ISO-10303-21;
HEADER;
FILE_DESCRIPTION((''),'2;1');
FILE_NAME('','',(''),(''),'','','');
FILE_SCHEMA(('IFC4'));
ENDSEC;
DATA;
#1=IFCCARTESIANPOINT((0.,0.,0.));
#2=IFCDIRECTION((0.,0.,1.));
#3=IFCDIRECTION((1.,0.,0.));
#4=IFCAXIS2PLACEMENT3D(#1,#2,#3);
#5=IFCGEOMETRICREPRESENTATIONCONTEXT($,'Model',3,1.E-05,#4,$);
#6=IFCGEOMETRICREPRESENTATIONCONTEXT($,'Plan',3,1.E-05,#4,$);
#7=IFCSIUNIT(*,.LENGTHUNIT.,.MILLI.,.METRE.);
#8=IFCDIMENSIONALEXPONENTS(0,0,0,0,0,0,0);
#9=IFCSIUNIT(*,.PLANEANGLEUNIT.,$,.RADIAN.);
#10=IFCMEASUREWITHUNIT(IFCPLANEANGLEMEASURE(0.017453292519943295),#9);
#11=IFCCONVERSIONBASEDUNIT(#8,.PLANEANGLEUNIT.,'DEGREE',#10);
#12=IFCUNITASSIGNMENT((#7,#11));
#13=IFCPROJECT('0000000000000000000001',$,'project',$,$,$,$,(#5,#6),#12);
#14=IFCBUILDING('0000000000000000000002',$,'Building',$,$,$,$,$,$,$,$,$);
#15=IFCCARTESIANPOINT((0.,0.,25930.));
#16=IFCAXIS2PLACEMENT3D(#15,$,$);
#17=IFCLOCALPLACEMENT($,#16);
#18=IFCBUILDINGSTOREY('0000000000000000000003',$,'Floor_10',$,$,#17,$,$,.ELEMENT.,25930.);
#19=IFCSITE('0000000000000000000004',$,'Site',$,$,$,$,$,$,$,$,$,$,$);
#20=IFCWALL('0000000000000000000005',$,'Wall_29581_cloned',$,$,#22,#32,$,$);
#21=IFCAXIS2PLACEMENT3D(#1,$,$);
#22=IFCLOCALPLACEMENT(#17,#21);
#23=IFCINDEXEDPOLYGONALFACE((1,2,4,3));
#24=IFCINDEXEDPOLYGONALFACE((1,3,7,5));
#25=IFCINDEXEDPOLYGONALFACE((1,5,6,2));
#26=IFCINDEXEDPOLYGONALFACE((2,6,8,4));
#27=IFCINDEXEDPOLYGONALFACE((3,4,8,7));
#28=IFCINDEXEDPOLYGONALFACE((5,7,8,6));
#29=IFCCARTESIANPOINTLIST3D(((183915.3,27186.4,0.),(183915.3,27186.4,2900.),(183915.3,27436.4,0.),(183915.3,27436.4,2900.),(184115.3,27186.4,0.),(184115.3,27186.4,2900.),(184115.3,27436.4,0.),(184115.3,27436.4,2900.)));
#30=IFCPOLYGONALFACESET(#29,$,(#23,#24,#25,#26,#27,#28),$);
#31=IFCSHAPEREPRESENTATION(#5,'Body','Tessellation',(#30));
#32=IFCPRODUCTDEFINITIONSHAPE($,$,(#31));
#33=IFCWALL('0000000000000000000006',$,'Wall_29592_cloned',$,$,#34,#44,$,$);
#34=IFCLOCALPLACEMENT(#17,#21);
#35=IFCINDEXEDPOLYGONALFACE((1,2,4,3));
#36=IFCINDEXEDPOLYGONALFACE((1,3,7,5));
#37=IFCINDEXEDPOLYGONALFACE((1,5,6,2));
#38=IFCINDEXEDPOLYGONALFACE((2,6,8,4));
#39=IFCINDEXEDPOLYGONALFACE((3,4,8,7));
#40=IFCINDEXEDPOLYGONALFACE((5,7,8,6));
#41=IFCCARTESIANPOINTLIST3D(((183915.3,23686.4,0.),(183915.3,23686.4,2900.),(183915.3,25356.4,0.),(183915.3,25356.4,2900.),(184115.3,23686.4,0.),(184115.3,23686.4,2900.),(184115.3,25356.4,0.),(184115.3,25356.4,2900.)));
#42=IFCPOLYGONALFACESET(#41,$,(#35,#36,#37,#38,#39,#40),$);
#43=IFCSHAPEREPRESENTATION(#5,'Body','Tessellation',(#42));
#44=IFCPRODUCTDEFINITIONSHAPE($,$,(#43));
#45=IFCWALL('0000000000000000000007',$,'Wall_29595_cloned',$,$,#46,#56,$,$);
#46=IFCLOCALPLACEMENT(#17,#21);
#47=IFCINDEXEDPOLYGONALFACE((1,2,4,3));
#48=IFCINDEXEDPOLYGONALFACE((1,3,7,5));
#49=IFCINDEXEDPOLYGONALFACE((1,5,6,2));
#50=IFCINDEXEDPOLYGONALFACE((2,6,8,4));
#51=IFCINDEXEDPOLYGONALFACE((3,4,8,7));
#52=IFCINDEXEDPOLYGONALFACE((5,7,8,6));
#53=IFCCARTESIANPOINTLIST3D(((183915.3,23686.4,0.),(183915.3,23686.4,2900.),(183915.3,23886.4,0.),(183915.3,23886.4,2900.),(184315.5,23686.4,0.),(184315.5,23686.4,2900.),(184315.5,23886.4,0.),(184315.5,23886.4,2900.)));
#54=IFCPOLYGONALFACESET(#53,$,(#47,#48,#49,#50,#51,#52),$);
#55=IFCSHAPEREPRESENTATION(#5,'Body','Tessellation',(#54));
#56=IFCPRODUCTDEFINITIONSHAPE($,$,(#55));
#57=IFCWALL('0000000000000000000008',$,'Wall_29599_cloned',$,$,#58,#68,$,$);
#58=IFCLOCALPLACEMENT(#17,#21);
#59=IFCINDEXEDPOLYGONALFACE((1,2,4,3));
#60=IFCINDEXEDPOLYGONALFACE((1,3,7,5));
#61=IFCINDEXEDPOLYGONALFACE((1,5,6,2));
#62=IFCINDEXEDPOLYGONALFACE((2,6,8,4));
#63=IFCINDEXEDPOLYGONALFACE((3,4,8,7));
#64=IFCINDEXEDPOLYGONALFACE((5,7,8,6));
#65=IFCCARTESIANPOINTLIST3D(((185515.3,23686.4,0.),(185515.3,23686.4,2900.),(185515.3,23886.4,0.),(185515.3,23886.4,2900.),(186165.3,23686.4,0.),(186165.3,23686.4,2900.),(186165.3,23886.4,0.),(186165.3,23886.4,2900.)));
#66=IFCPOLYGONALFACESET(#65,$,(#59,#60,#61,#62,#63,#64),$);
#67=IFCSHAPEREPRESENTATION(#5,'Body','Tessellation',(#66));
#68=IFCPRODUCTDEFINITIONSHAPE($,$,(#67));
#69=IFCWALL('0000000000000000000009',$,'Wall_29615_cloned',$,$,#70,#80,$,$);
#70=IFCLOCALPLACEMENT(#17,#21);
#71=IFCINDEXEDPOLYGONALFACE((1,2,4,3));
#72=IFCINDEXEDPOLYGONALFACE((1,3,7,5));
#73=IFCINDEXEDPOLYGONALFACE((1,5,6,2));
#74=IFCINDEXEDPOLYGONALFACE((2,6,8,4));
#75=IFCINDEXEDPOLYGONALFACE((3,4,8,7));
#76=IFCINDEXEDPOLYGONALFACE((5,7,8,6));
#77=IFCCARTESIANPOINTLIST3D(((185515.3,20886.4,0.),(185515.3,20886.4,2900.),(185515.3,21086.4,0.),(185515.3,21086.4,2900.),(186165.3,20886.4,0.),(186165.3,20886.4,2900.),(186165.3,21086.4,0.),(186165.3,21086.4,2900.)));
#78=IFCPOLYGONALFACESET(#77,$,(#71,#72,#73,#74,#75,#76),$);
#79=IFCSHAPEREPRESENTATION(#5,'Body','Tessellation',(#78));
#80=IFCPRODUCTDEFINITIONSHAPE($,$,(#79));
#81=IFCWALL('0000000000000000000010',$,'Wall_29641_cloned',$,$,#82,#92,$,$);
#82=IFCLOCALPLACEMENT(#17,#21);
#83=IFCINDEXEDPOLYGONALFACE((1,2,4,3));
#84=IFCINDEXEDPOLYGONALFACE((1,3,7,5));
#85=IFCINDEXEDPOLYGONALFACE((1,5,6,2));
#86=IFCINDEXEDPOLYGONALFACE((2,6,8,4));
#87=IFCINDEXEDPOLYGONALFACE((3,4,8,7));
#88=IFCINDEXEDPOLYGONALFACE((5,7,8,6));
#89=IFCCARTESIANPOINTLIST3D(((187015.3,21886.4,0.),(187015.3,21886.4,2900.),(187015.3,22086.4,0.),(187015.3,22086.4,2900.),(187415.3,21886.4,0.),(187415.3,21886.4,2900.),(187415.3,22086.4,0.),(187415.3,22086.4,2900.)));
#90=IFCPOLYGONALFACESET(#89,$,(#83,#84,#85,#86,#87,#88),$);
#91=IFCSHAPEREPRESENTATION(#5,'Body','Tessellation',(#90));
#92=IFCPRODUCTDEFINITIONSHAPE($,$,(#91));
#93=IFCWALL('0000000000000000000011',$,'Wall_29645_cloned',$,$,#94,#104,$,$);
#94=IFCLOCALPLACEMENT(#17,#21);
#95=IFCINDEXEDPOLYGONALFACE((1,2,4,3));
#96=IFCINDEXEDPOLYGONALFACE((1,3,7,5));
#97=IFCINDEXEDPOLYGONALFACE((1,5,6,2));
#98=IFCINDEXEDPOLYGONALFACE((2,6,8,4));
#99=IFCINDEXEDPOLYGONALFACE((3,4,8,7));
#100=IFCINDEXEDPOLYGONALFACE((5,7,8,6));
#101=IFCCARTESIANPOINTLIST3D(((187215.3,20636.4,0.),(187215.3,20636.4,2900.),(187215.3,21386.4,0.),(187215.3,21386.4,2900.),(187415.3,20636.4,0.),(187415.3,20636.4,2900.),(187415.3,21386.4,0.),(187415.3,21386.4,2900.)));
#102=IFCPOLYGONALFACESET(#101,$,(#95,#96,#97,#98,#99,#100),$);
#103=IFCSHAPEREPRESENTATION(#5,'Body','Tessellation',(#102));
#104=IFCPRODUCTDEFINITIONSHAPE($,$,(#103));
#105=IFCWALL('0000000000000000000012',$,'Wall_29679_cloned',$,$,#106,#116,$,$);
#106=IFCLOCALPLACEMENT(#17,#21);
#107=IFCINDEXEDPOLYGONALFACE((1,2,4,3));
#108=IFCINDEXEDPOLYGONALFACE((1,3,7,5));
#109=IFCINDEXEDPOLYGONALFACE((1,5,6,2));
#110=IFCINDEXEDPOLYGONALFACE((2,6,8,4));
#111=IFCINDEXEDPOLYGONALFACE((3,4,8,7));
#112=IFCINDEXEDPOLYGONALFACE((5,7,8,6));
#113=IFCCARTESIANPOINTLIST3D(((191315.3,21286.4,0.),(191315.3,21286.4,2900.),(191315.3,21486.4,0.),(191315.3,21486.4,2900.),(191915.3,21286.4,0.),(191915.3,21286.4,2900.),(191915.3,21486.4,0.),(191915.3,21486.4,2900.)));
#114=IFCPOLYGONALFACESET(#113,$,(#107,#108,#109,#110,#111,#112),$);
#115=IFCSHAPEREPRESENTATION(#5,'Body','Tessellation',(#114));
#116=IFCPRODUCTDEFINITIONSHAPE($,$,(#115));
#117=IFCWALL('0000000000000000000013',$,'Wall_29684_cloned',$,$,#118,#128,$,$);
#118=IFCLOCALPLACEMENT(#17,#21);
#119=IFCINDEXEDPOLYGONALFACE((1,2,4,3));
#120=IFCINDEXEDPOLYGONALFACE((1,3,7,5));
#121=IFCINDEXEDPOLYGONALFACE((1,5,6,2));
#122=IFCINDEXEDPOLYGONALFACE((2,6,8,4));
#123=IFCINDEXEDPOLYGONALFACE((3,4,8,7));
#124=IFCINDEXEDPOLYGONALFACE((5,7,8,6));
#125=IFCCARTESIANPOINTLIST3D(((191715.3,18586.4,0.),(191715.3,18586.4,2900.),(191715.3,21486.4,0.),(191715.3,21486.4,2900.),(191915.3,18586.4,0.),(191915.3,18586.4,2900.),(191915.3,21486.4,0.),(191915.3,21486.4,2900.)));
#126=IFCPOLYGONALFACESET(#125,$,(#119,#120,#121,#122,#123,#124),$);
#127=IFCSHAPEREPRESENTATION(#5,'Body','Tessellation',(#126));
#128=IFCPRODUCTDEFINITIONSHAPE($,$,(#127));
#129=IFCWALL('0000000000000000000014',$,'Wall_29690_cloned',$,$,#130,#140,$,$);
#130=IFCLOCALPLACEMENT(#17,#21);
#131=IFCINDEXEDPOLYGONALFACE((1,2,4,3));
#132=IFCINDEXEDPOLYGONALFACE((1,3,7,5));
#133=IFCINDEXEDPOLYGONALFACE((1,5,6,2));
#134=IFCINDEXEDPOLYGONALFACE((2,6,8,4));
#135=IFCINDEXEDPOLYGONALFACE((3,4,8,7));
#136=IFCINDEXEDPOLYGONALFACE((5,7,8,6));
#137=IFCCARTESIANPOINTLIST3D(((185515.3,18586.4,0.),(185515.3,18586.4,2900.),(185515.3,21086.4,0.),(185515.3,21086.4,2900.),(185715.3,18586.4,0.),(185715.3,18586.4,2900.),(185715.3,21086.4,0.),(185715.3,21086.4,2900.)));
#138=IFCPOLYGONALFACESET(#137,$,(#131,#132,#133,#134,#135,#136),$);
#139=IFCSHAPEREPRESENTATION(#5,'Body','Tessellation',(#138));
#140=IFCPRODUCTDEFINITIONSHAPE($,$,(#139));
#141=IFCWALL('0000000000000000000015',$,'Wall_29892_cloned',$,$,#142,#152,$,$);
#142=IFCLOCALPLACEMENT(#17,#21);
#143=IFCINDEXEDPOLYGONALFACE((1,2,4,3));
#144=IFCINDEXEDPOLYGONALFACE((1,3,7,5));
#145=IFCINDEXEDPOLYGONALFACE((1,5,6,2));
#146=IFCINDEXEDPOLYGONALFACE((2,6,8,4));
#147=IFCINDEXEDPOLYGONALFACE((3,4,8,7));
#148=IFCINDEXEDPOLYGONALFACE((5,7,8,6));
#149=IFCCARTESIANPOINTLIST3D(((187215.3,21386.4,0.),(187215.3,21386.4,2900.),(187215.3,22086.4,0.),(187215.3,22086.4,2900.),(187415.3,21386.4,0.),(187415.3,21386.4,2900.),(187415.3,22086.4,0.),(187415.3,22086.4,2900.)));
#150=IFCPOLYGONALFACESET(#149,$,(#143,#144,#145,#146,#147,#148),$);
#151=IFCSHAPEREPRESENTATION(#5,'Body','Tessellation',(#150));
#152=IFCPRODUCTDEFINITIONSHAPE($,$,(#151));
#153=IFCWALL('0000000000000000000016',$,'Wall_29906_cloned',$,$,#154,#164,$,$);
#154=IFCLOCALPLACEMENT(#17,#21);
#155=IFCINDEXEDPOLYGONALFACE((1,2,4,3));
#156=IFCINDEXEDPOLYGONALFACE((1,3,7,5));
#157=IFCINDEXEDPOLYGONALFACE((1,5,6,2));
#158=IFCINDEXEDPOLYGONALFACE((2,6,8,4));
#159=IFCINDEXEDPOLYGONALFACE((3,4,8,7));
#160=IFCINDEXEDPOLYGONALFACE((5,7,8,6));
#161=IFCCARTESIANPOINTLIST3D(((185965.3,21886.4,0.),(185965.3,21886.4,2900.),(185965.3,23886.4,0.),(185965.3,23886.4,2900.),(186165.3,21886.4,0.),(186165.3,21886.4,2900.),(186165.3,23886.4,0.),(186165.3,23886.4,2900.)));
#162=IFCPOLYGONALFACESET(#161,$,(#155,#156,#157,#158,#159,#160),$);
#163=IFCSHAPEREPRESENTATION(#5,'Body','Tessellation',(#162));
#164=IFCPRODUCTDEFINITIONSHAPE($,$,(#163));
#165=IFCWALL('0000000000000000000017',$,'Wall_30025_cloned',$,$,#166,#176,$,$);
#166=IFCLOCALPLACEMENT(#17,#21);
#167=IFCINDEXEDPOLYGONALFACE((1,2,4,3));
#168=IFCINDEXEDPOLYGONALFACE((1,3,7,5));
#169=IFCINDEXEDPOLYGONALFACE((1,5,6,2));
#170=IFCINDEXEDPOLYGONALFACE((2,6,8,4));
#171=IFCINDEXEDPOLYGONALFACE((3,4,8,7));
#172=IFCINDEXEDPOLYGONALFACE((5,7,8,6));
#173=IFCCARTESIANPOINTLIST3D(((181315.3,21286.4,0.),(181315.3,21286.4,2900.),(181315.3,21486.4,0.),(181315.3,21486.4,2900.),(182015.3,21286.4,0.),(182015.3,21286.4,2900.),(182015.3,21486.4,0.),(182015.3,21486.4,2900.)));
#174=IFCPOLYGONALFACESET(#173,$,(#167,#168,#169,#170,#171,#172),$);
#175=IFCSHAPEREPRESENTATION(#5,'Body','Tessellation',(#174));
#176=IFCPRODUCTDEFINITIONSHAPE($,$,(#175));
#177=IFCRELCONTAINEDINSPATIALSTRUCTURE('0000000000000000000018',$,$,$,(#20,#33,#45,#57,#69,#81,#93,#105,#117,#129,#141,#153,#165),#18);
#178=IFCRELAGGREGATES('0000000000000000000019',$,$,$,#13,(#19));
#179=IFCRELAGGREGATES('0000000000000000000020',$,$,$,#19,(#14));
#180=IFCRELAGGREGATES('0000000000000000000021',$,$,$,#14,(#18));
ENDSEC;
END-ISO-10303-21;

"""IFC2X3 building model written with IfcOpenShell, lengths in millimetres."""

from ifc_helpers import new_model, entity, si_unit, converted_unit, frame, origin_with_axes, origin_2d, place, context, project, spatial, rectangle, extrude, source, transform, mapped, element, save


model = new_model("IFC2X3")

# Units and contexts
model_context = context("Model", 3, precision=1e-05, world=origin_with_axes())
plan_context = context("Plan", 3, precision=1e-05, world=origin_with_axes())
ifc_project = project(units=[si_unit("LENGTHUNIT", "METRE", prefix="MILLI"), converted_unit("PLANEANGLEUNIT", "DEGREE", entity("IfcPlaneAngleMeasure", 0.017453292519943295), si_unit("PLANEANGLEUNIT", "RADIAN"), dimensions=[0, 0, 0, 0, 0, 0, 0])], contexts=[model_context, plan_context])

# Site, building, storey
site = spatial("IfcSite", under=ifc_project, Name="Site")
building = spatial("IfcBuilding", under=site, Name="Building")
storey_placement = place(None, frame((0.0, 0.0, 25930.0)))
storey = spatial("IfcBuildingStorey", under=building, at=storey_placement, Name="Floor_10", CompositionType="ELEMENT", Elevation=25930.0)

# Walls
shared_shape_1 = source(origin_with_axes(), model_context, "Body", "SweptSolid", [
    extrude(rectangle(XDim=250.0, YDim=200.0, at=origin_2d()), origin_with_axes(), (0.0, 0.0, 1.0), 2900.0),
])
wall_1_placement = place(storey_placement, frame((184015.3, 27311.4, 0.0), z_axis=(0.0, 0.0, 1.0), x_axis=(0.0, 249.999994, 0.0)))
element("IfcWall", 1, at=wall_1_placement, inside=storey, Name="Wall_29581_cloned", context=model_context, shape_type="MappedRepresentation", body=[
    mapped(shared_shape_1, transform((0.0, 0.0, 0.0), x_axis=(1.0, 0.0, 0.0), y_axis=(0.0, 1.0, 0.0), z_axis=(0.0, 0.0, 1.0), scale=1.0)),
])
shared_shape_2 = source(origin_with_axes(), model_context, "Body", "SweptSolid", [
    extrude(rectangle(XDim=1670.0, YDim=200.0, at=origin_2d()), origin_with_axes(), (0.0, 0.0, 1.0), 2900.0),
])
wall_2_placement = place(storey_placement, frame((184015.3, 24521.4, 0.0), z_axis=(0.0, 0.0, 1.0), x_axis=(0.0, 1669.999996, 0.0)))
element("IfcWall", 2, at=wall_2_placement, inside=storey, Name="Wall_29592_cloned", context=model_context, shape_type="MappedRepresentation", body=[
    mapped(shared_shape_2, transform((0.0, 0.0, 0.0), x_axis=(1.0, 0.0, 0.0), y_axis=(0.0, 1.0, 0.0), z_axis=(0.0, 0.0, 1.0), scale=1.0)),
])
shared_shape_3 = source(origin_with_axes(), model_context, "Body", "SweptSolid", [
    extrude(rectangle(XDim=400.1, YDim=200.0, at=origin_2d()), origin_with_axes(), (0.0, 0.0, 1.0), 2900.0),
])
wall_3_placement = place(storey_placement, frame((184115.4, 23786.4, 0.0), z_axis=(0.0, 0.0, 1.0), x_axis=(400.146534, -0.000012, 0.0)))
element("IfcWall", 3, at=wall_3_placement, inside=storey, Name="Wall_29595_cloned", context=model_context, shape_type="MappedRepresentation", body=[
    mapped(shared_shape_3, transform((0.0, 0.0, 0.0), x_axis=(1.0, 0.0, 0.0), y_axis=(0.0, 1.0, 0.0), z_axis=(0.0, 0.0, 1.0), scale=1.0)),
])
shared_shape_4 = source(origin_with_axes(), model_context, "Body", "SweptSolid", [
    extrude(rectangle(XDim=650.0, YDim=200.0, at=origin_2d()), origin_with_axes(), (0.0, 0.0, 1.0), 2900.0),
])
wall_4_placement = place(storey_placement, frame((185840.3, 23786.4, 0.0), z_axis=(0.0, 0.0, 1.0), x_axis=(650.0, 0.0, 0.0)))
element("IfcWall", 4, at=wall_4_placement, inside=storey, Name="Wall_29599_cloned", context=model_context, shape_type="MappedRepresentation", body=[
    mapped(shared_shape_4, transform((0.0, 0.0, 0.0), x_axis=(1.0, 0.0, 0.0), y_axis=(0.0, 1.0, 0.0), z_axis=(0.0, 0.0, 1.0), scale=1.0)),
])
shared_shape_5 = source(origin_with_axes(), model_context, "Body", "SweptSolid", [
    extrude(rectangle(XDim=650.0, YDim=200.0, at=origin_2d()), origin_with_axes(), (0.0, 0.0, 1.0), 2900.0),
])
wall_5_placement = place(storey_placement, frame((185840.3, 20986.4, 0.0), z_axis=(0.0, 0.0, 1.0), x_axis=(650.0, 0.0, 0.0)))
element("IfcWall", 5, at=wall_5_placement, inside=storey, Name="Wall_29615_cloned", context=model_context, shape_type="MappedRepresentation", body=[
    mapped(shared_shape_5, transform((0.0, 0.0, 0.0), x_axis=(1.0, 0.0, 0.0), y_axis=(0.0, 1.0, 0.0), z_axis=(0.0, 0.0, 1.0), scale=1.0)),
])
shared_shape_6 = source(origin_with_axes(), model_context, "Body", "SweptSolid", [
    extrude(rectangle(XDim=400.0, YDim=200.0, at=origin_2d()), origin_with_axes(), (0.0, 0.0, 1.0), 2900.0),
])
wall_6_placement = place(storey_placement, frame((187215.3, 21986.4, 0.0), z_axis=(0.0, 0.0, 1.0), x_axis=(400.0, 0.0, 0.0)))
element("IfcWall", 6, at=wall_6_placement, inside=storey, Name="Wall_29641_cloned", context=model_context, shape_type="MappedRepresentation", body=[
    mapped(shared_shape_6, transform((0.0, 0.0, 0.0), x_axis=(1.0, 0.0, 0.0), y_axis=(0.0, 1.0, 0.0), z_axis=(0.0, 0.0, 1.0), scale=1.0)),
])
shared_shape_7 = source(origin_with_axes(), model_context, "Body", "SweptSolid", [
    extrude(rectangle(XDim=750.0, YDim=200.0, at=origin_2d()), origin_with_axes(), (0.0, 0.0, 1.0), 2900.0),
])
wall_7_placement = place(storey_placement, frame((187315.3, 21011.4, 0.0), z_axis=(0.0, 0.0, 1.0), x_axis=(0.0, 750.0, 0.0)))
element("IfcWall", 7, at=wall_7_placement, inside=storey, Name="Wall_29645_cloned", context=model_context, shape_type="MappedRepresentation", body=[
    mapped(shared_shape_7, transform((0.0, 0.0, 0.0), x_axis=(1.0, 0.0, 0.0), y_axis=(0.0, 1.0, 0.0), z_axis=(0.0, 0.0, 1.0), scale=1.0)),
])
shared_shape_8 = source(origin_with_axes(), model_context, "Body", "SweptSolid", [
    extrude(rectangle(XDim=600.0, YDim=200.0, at=origin_2d()), origin_with_axes(), (0.0, 0.0, 1.0), 2900.0),
])
wall_8_placement = place(storey_placement, frame((191615.3, 21386.4, 0.0), z_axis=(0.0, 0.0, 1.0), x_axis=(600.0, 0.0, 0.0)))
element("IfcWall", 8, at=wall_8_placement, inside=storey, Name="Wall_29679_cloned", context=model_context, shape_type="MappedRepresentation", body=[
    mapped(shared_shape_8, transform((0.0, 0.0, 0.0), x_axis=(1.0, 0.0, 0.0), y_axis=(0.0, 1.0, 0.0), z_axis=(0.0, 0.0, 1.0), scale=1.0)),
])
shared_shape_9 = source(origin_with_axes(), model_context, "Body", "SweptSolid", [
    extrude(rectangle(XDim=2900.0, YDim=200.0, at=origin_2d()), origin_with_axes(), (0.0, 0.0, 1.0), 2900.0),
])
wall_9_placement = place(storey_placement, frame((191815.3, 20036.4, 0.0), z_axis=(0.0, 0.0, 1.0), x_axis=(0.0, 2900.0, 0.0)))
element("IfcWall", 9, at=wall_9_placement, inside=storey, Name="Wall_29684_cloned", context=model_context, shape_type="MappedRepresentation", body=[
    mapped(shared_shape_9, transform((0.0, 0.0, 0.0), x_axis=(1.0, 0.0, 0.0), y_axis=(0.0, 1.0, 0.0), z_axis=(0.0, 0.0, 1.0), scale=1.0)),
])
shared_shape_10 = source(origin_with_axes(), model_context, "Body", "SweptSolid", [
    extrude(rectangle(XDim=2500.0, YDim=200.0, at=origin_2d()), origin_with_axes(), (0.0, 0.0, 1.0), 2900.0),
])
wall_10_placement = place(storey_placement, frame((185615.3, 19836.4, 0.0), z_axis=(0.0, 0.0, 1.0), x_axis=(0.0, 2500.0, 0.0)))
element("IfcWall", 10, at=wall_10_placement, inside=storey, Name="Wall_29690_cloned", context=model_context, shape_type="MappedRepresentation", body=[
    mapped(shared_shape_10, transform((0.0, 0.0, 0.0), x_axis=(1.0, 0.0, 0.0), y_axis=(0.0, 1.0, 0.0), z_axis=(0.0, 0.0, 1.0), scale=1.0)),
])
shared_shape_11 = source(origin_with_axes(), model_context, "Body", "SweptSolid", [
    extrude(rectangle(XDim=700.0, YDim=200.0, at=origin_2d()), origin_with_axes(), (0.0, 0.0, 1.0), 2900.0),
])
wall_11_placement = place(storey_placement, frame((187315.3, 21736.4, 0.0), z_axis=(0.0, 0.0, 1.0), x_axis=(0.0, 700.0, 0.0)))
element("IfcWall", 11, at=wall_11_placement, inside=storey, Name="Wall_29892_cloned", context=model_context, shape_type="MappedRepresentation", body=[
    mapped(shared_shape_11, transform((0.0, 0.0, 0.0), x_axis=(1.0, 0.0, 0.0), y_axis=(0.0, 1.0, 0.0), z_axis=(0.0, 0.0, 1.0), scale=1.0)),
])
shared_shape_12 = source(origin_with_axes(), model_context, "Body", "SweptSolid", [
    extrude(rectangle(XDim=2000.0, YDim=200.0, at=origin_2d()), origin_with_axes(), (0.0, 0.0, 1.0), 2900.0),
])
wall_12_placement = place(storey_placement, frame((186065.3, 22886.4, 0.0), z_axis=(0.0, 0.0, 1.0), x_axis=(0.0, 2000.0, 0.0)))
element("IfcWall", 12, at=wall_12_placement, inside=storey, Name="Wall_29906_cloned", context=model_context, shape_type="MappedRepresentation", body=[
    mapped(shared_shape_12, transform((0.0, 0.0, 0.0), x_axis=(1.0, 0.0, 0.0), y_axis=(0.0, 1.0, 0.0), z_axis=(0.0, 0.0, 1.0), scale=1.0)),
])
shared_shape_13 = source(origin_with_axes(), model_context, "Body", "SweptSolid", [
    extrude(rectangle(XDim=700.0, YDim=200.0, at=origin_2d()), origin_with_axes(), (0.0, 0.0, 1.0), 2900.0),
])
wall_13_placement = place(storey_placement, frame((181665.3, 21386.4, 0.0), z_axis=(0.0, 0.0, 1.0), x_axis=(699.999906, 0.0, 0.0)))
element("IfcWall", 13, at=wall_13_placement, inside=storey, Name="Wall_30025_cloned", context=model_context, shape_type="MappedRepresentation", body=[
    mapped(shared_shape_13, transform((0.0, 0.0, 0.0), x_axis=(1.0, 0.0, 0.0), y_axis=(0.0, 1.0, 0.0), z_axis=(0.0, 0.0, 1.0), scale=1.0)),
])

save(model, "model.ifc")
